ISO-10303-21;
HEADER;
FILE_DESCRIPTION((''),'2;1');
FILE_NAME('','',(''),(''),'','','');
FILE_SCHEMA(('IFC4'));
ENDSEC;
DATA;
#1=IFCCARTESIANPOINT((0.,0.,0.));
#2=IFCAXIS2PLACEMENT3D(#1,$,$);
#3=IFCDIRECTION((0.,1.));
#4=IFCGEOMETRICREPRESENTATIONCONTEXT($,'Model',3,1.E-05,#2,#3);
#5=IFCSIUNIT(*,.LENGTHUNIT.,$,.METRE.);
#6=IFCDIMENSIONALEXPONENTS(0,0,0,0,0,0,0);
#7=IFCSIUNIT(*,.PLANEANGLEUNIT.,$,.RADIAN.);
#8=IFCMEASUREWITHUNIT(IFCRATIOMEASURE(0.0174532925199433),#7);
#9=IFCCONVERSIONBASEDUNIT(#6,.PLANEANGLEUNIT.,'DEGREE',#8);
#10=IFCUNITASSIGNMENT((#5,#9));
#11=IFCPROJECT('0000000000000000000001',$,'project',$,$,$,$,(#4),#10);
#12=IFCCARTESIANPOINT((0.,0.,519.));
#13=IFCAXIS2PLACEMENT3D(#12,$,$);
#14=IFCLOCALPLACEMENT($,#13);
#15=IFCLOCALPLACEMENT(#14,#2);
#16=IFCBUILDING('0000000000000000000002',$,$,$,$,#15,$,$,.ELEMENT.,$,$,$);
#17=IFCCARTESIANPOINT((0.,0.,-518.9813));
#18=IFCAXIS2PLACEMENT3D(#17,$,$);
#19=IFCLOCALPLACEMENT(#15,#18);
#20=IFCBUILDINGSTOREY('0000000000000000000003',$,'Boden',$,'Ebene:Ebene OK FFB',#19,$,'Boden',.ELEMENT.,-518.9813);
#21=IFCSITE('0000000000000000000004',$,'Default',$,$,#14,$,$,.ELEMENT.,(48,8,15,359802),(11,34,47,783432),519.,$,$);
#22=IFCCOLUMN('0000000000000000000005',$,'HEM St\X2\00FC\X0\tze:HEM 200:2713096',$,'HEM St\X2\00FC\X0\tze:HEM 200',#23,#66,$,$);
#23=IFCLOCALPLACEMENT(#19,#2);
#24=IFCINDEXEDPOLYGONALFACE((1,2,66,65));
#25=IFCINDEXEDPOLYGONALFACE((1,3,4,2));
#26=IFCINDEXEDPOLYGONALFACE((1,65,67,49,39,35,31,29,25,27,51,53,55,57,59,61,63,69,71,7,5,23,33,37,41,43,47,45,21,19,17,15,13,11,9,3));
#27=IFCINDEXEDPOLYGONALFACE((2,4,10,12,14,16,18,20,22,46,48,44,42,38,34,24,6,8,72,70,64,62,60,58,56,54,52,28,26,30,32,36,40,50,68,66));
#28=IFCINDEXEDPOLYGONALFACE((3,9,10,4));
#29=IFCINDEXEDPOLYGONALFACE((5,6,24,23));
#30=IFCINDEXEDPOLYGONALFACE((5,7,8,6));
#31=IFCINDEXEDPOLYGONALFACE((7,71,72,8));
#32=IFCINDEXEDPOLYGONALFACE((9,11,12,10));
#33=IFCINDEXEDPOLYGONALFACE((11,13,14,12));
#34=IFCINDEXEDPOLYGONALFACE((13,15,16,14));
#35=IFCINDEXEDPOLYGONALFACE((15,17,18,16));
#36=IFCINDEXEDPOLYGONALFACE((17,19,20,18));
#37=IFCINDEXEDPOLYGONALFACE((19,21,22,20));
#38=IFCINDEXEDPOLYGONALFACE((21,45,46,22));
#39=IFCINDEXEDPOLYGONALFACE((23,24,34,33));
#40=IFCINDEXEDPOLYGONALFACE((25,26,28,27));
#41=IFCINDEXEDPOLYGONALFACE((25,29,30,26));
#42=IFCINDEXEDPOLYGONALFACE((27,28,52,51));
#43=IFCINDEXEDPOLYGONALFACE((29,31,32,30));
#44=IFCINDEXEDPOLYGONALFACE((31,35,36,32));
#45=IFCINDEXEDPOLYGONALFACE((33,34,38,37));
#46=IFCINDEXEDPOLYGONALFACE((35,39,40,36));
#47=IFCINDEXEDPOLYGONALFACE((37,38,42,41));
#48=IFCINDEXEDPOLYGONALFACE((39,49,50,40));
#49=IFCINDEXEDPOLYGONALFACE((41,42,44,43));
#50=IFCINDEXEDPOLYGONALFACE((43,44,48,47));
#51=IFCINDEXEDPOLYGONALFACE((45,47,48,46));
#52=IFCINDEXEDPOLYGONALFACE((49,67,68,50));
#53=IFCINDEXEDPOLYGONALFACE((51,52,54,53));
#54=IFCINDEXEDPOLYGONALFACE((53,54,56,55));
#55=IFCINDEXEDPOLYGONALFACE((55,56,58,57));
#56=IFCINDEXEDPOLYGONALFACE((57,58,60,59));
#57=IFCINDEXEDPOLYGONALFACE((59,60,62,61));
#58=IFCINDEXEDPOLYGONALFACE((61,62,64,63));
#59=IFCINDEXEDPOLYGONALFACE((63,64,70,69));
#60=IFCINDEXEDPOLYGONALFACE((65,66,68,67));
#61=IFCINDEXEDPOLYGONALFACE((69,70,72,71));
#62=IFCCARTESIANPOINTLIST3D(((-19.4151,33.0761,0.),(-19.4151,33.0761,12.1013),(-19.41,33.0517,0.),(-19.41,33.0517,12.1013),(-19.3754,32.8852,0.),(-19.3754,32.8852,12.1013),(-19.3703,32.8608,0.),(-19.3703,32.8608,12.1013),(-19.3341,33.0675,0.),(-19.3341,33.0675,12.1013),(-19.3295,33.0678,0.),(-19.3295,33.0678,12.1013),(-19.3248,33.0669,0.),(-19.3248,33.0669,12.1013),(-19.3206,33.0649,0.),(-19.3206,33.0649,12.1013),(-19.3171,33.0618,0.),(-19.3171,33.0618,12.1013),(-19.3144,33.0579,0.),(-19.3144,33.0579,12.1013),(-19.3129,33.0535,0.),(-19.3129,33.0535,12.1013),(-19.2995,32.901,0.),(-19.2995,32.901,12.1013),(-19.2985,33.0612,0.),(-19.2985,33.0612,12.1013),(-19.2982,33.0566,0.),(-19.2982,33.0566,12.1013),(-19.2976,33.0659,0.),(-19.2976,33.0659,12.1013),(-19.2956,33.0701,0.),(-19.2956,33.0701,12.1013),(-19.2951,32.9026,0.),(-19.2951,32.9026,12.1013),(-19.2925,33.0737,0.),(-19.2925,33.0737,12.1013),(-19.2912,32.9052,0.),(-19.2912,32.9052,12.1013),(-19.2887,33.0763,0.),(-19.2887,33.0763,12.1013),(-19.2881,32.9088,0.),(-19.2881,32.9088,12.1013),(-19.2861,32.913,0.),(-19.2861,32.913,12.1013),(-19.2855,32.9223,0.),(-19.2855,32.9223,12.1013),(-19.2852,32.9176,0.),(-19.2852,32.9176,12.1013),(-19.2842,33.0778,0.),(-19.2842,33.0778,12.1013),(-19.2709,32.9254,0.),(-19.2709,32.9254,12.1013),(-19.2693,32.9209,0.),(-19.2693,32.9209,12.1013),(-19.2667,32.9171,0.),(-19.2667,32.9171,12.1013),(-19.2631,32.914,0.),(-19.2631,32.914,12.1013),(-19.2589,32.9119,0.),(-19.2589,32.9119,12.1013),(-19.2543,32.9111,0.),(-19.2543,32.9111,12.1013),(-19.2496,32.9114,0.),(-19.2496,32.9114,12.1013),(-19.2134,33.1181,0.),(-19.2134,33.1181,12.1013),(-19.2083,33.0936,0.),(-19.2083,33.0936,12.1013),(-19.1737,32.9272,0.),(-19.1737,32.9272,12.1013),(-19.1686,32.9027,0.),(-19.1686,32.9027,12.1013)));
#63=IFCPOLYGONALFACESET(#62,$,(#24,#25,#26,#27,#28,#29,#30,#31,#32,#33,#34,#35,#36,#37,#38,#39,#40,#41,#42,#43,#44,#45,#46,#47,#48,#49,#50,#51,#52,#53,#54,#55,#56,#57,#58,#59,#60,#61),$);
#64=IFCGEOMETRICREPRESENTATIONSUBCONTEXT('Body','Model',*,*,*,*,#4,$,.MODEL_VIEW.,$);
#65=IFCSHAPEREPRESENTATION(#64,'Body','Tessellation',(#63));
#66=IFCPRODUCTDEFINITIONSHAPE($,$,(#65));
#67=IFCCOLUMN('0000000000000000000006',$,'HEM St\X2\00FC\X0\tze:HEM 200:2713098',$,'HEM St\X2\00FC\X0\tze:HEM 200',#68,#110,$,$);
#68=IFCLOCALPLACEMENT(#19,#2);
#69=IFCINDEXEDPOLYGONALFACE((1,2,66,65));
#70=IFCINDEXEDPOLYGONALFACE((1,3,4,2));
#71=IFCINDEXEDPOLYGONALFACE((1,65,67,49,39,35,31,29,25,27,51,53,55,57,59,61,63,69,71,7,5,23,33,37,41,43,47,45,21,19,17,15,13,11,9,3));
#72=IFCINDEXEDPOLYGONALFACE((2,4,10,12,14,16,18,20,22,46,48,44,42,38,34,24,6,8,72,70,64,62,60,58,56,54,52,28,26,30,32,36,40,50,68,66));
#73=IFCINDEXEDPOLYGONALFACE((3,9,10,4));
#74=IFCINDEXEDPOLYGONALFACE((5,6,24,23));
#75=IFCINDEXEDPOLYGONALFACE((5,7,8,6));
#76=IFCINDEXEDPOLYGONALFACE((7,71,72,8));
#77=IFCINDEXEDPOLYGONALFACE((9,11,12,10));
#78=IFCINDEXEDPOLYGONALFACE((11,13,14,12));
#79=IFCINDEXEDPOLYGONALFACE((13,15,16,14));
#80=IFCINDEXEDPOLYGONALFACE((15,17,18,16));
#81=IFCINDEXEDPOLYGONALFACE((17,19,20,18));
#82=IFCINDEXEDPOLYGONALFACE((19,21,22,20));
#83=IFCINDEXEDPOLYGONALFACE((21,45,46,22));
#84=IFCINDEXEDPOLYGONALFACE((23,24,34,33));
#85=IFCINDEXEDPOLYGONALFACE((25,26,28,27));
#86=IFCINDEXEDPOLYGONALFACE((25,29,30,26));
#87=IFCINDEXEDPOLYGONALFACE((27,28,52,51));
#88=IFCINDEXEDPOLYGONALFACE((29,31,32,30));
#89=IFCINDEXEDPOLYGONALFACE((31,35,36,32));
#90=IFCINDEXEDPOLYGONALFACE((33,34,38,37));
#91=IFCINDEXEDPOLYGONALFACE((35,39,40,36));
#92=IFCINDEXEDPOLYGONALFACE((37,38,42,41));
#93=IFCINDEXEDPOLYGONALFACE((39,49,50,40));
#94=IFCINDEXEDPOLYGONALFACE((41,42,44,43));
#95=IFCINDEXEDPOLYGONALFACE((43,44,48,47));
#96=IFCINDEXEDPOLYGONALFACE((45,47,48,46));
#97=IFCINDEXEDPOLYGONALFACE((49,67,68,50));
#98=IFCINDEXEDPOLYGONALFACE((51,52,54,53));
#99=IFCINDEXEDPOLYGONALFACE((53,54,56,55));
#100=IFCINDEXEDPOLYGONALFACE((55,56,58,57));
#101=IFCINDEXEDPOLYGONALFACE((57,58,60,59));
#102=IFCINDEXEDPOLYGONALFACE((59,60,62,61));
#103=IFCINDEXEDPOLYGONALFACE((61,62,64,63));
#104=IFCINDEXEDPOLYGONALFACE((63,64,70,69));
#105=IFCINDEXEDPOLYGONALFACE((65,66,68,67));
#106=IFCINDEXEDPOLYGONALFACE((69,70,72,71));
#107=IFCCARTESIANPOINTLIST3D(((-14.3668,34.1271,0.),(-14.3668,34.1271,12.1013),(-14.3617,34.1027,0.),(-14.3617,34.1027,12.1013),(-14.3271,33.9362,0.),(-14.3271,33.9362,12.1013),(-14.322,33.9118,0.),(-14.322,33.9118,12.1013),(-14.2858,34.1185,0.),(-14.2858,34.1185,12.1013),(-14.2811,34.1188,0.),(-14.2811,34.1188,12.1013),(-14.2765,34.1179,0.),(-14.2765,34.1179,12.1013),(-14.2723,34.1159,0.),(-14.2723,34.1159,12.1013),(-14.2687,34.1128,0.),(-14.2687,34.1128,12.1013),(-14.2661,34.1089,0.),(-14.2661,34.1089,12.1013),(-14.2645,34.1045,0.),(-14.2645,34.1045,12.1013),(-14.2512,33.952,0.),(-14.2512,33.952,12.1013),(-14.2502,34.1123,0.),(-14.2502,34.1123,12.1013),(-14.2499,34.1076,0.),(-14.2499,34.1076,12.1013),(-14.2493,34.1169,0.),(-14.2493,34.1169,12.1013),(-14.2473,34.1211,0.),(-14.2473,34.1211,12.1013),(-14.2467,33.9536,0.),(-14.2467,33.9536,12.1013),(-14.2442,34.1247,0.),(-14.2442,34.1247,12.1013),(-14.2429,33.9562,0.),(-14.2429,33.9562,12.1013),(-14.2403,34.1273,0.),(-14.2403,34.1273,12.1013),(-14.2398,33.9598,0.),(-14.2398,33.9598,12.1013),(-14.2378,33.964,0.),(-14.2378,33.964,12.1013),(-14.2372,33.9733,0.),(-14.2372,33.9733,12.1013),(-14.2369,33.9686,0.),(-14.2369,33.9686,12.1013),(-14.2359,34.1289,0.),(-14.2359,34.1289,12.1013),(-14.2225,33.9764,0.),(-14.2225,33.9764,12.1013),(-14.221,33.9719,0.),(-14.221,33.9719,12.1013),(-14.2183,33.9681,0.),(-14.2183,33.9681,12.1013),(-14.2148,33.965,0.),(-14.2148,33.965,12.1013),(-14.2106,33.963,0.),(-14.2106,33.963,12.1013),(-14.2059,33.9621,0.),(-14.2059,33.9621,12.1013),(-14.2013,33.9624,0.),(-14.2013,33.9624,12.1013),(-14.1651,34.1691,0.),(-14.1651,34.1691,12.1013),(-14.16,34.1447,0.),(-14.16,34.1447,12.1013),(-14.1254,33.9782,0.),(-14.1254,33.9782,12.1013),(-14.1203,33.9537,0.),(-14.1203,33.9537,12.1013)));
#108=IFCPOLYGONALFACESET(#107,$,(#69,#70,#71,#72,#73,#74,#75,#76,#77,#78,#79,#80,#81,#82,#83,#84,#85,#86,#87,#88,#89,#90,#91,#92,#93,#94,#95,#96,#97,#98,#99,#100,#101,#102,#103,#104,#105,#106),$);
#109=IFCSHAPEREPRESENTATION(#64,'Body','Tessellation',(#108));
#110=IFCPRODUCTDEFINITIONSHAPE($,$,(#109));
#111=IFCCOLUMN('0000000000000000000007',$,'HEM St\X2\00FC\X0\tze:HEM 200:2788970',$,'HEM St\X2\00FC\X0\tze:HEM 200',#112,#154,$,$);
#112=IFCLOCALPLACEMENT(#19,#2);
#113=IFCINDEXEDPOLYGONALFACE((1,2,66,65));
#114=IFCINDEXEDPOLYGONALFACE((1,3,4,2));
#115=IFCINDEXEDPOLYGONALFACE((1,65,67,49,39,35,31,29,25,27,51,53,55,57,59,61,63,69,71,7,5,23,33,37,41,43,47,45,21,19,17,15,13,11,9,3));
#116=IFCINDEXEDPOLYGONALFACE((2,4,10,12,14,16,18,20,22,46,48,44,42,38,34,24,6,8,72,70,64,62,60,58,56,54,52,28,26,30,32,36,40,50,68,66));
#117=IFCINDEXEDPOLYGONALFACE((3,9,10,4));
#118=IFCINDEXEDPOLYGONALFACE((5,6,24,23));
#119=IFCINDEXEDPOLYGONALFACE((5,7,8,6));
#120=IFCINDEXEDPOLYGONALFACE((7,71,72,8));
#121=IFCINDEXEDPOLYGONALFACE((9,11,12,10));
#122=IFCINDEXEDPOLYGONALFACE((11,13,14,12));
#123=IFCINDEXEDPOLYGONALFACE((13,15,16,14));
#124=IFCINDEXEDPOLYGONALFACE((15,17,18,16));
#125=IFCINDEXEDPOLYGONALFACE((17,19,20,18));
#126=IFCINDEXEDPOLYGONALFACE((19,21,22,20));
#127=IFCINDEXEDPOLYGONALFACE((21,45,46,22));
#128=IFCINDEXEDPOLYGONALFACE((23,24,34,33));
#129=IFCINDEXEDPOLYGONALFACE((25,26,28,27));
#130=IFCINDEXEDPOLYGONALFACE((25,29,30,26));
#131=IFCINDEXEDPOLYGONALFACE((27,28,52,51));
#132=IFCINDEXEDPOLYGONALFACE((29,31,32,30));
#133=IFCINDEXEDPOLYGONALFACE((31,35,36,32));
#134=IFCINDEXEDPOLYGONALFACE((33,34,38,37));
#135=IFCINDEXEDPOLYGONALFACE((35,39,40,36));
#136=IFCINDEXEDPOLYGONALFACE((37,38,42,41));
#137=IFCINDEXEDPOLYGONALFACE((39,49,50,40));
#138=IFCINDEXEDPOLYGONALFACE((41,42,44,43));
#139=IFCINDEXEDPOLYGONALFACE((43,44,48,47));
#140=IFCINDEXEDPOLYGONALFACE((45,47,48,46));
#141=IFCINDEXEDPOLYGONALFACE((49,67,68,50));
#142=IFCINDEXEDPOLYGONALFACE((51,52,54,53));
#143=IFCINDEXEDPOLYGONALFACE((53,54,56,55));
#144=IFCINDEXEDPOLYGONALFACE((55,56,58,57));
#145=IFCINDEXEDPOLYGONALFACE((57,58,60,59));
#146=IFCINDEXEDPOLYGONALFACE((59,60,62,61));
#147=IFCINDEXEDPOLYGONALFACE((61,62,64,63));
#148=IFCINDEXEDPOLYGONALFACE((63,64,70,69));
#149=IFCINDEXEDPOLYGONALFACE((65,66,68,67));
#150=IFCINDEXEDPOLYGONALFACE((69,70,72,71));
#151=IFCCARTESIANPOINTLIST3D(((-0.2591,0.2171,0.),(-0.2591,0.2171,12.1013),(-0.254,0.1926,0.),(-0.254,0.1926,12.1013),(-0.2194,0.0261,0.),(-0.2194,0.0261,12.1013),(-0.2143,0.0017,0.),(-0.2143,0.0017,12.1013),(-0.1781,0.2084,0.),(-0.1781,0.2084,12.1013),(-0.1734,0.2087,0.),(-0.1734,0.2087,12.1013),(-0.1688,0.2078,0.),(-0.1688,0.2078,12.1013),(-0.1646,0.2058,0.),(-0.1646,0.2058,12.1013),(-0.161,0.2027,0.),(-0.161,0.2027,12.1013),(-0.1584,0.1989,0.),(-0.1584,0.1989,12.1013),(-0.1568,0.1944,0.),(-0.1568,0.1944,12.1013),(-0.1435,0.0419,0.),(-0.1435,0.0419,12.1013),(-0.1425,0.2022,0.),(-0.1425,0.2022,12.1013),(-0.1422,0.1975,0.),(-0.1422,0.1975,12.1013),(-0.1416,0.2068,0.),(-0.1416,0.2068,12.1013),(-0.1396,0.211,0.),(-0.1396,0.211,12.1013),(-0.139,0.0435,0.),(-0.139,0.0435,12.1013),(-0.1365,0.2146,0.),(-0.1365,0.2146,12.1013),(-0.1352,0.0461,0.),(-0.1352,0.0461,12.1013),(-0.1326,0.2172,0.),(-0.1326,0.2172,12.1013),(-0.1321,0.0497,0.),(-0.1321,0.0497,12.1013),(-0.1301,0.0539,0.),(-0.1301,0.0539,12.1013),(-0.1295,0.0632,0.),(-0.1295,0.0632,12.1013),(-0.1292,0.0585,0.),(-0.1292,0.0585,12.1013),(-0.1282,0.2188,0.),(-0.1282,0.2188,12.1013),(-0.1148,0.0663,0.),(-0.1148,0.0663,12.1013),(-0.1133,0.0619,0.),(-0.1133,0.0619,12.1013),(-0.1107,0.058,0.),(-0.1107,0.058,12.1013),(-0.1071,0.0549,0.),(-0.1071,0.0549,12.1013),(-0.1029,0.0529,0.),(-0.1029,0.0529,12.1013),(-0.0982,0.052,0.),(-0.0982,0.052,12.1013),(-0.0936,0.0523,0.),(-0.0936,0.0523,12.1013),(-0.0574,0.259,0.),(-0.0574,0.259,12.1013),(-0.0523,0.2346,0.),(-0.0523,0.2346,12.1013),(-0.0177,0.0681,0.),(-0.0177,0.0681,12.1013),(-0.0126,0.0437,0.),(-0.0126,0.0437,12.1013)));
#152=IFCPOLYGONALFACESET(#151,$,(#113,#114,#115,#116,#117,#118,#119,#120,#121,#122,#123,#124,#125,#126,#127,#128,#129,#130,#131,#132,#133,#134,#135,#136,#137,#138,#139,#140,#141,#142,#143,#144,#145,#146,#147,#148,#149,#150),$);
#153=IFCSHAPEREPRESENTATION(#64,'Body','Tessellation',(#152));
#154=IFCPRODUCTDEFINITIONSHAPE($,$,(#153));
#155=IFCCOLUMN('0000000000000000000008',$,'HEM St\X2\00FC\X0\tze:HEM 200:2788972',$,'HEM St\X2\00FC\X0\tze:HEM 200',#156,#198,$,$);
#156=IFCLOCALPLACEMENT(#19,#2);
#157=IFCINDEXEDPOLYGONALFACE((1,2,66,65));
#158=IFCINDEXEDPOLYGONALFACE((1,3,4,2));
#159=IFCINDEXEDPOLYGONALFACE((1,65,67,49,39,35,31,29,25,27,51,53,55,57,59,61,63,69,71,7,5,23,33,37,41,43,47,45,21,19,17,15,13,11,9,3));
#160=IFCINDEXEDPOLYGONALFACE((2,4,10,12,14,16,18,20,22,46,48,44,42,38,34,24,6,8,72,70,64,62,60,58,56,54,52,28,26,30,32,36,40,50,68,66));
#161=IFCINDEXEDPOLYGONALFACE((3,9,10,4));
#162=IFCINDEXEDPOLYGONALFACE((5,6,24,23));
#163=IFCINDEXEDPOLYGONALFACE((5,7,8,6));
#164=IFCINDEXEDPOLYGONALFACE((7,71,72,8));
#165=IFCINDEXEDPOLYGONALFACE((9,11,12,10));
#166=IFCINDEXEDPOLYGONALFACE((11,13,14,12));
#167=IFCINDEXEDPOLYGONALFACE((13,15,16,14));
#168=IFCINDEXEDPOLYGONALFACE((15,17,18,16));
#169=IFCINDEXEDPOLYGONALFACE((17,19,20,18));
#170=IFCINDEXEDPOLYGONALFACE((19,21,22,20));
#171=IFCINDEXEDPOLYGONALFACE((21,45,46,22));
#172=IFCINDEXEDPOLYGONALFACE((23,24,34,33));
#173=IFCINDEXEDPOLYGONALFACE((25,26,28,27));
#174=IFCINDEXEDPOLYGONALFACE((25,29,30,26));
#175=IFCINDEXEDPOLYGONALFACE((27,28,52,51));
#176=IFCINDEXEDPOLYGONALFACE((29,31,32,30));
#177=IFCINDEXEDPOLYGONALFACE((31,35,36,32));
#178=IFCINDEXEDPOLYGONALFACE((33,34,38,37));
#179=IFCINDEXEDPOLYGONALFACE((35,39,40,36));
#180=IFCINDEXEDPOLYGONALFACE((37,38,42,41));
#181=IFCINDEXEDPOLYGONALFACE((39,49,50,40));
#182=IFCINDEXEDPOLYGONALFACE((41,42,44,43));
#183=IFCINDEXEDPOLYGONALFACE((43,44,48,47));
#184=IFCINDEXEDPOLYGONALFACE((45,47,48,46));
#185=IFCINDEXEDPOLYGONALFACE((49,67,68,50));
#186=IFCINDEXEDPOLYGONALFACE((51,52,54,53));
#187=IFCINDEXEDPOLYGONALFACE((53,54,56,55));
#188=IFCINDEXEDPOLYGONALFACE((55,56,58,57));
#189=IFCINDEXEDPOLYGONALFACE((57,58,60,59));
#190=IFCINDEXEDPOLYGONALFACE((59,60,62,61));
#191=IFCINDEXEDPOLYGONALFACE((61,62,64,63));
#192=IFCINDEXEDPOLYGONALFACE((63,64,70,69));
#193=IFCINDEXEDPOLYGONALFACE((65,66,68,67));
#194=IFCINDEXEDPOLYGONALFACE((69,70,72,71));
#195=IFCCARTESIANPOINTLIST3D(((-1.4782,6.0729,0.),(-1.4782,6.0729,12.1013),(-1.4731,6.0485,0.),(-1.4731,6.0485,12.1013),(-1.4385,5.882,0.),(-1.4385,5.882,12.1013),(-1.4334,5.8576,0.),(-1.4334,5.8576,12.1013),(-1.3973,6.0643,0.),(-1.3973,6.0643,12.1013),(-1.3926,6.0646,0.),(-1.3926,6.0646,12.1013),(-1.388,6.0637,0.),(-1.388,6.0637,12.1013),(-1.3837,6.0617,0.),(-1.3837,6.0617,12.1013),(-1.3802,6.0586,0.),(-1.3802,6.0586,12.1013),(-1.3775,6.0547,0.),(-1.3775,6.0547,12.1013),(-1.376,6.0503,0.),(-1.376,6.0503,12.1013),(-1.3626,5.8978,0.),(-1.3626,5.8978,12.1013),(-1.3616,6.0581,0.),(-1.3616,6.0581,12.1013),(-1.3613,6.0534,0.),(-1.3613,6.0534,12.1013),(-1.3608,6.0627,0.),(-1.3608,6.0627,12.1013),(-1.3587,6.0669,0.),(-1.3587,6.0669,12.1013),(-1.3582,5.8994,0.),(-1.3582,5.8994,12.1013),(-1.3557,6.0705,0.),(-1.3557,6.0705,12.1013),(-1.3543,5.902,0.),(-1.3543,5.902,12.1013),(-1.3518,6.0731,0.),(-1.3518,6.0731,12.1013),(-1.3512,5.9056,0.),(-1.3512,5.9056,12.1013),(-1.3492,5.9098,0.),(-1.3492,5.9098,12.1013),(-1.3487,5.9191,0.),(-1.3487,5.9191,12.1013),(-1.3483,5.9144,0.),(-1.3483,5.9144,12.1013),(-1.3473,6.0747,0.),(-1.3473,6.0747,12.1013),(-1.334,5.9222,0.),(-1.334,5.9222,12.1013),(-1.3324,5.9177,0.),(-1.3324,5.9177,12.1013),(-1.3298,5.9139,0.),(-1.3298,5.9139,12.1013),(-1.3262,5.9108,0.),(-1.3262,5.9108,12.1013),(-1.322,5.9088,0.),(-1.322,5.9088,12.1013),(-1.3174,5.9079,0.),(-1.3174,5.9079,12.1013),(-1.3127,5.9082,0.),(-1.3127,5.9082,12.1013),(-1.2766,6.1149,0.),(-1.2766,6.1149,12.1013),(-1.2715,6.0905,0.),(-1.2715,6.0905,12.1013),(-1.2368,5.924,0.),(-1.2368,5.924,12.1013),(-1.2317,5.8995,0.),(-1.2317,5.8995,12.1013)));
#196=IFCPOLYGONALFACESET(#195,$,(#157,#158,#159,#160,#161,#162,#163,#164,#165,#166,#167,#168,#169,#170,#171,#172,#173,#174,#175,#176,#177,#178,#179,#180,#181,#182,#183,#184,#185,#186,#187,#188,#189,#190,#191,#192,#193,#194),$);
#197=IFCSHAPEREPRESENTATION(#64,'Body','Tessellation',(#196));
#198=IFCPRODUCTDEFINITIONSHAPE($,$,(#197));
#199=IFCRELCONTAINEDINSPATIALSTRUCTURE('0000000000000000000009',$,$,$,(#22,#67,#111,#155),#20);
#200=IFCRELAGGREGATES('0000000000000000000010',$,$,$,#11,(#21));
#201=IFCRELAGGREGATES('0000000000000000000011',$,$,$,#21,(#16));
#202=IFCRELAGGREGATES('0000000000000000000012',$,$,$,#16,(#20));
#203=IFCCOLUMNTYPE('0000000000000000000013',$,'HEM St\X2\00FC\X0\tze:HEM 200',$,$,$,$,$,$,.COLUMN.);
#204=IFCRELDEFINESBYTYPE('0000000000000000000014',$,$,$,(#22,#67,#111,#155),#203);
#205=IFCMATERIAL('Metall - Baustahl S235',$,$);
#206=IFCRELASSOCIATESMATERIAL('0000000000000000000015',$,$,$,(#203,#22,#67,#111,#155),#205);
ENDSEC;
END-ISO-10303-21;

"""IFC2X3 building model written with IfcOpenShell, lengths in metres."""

from ifc_helpers import new_model, entity, si_unit, converted_unit, direction, frame, frame_2d, origin, place, context, subcontext, project, spatial, polyline, circle_curve, parameter, trimmed, segment, composite_curve, outline, extrude, source, transform, mapped, material, type_object, type_shapes, element, save


model = new_model("IFC2X3")

# Units and contexts
model_context = context("Model", 3, precision=1e-05, world=origin(), true_north=direction((0.0, 1.0)))
body_context = subcontext(model_context, "Body", "Model", "MODEL_VIEW")
ifc_project = project(units=[si_unit("LENGTHUNIT", "METRE"), converted_unit("PLANEANGLEUNIT", "DEGREE", entity("IfcRatioMeasure", 0.0174532925199433), si_unit("PLANEANGLEUNIT", "RADIAN"), dimensions=[0, 0, 0, 0, 0, 0, 0])], contexts=[model_context])

# Site, building, storey
site_placement = place(None, frame((0.0, 0.0, 519.0)))
site = spatial("IfcSite", under=ifc_project, at=site_placement, Name="Default", CompositionType="ELEMENT", RefLatitude=(48, 8, 15, 359802), RefLongitude=(11, 34, 47, 783432), RefElevation=519.0)
building_placement = place(site_placement, origin())
building = spatial("IfcBuilding", under=site, at=building_placement, CompositionType="ELEMENT")
storey_placement = place(building_placement, frame((0.0, 0.0, -518.9813)))
storey = spatial("IfcBuildingStorey", under=building, at=storey_placement, Name="Boden", ObjectType="Ebene:Ebene OK FFB", LongName="Boden", CompositionType="ELEMENT", Elevation=-518.9813)

# Columns
ifc_material = material(Name="Metall - Baustahl S235")
column_type_1 = type_object("IfcColumnType", Name="HEM Stütze:HEM 200", PredefinedType="COLUMN", material=ifc_material)
shared_shape_1 = source(origin(), body_context, "Body", "SweptSolid", [
    extrude(outline(composite_curve([segment(polyline([(0.085, -0.103), (0.11, -0.103)]), True, "CONTINUOUS"), segment(polyline([(0.11, -0.103), (0.11, 0.103)]), True, "CONTINUOUS"), segment(polyline([(0.11, 0.103), (0.085, 0.103)]), True, "CONTINUOUS"), segment(polyline([(0.085, 0.103), (0.085, 0.0255)]), True, "CONTINUOUS"), segment(trimmed(circle_curve(frame_2d((0.067, 0.0255), x_axis=(1.0, 0.0)), 0.018), [parameter(270.0)], [parameter(0.0)], True, "PARAMETER"), False, "CONTINUOUS"), segment(polyline([(0.067, 0.0075), (-0.067, 0.0075)]), True, "CONTINUOUS"), segment(trimmed(circle_curve(frame_2d((-0.067, 0.0255), x_axis=(0.0, -1.0)), 0.018), [parameter(270.0)], [parameter(0.0)], True, "PARAMETER"), False, "CONTINUOUS"), segment(polyline([(-0.085, 0.0255), (-0.085, 0.103)]), True, "CONTINUOUS"), segment(polyline([(-0.085, 0.103), (-0.11, 0.103)]), True, "CONTINUOUS"), segment(polyline([(-0.11, 0.103), (-0.11, -0.103)]), True, "CONTINUOUS"), segment(polyline([(-0.11, -0.103), (-0.085, -0.103)]), True, "CONTINUOUS"), segment(polyline([(-0.085, -0.103), (-0.085, -0.0255)]), True, "CONTINUOUS"), segment(trimmed(circle_curve(frame_2d((-0.067, -0.0255), x_axis=(-1.0, 0.0)), 0.018), [parameter(270.0)], [parameter(0.0)], True, "PARAMETER"), False, "CONTINUOUS"), segment(polyline([(-0.067, -0.0075), (0.067, -0.0075)]), True, "CONTINUOUS"), segment(trimmed(circle_curve(frame_2d((0.067, -0.0255), x_axis=(0.0, 1.0)), 0.018), [parameter(270.0)], [parameter(0.0)], True, "PARAMETER"), False, "CONTINUOUS"), segment(polyline([(0.085, -0.0255), (0.085, -0.103)]), True, "CONTINUOUS")], self_intersect=False)), frame((0.0, 0.0, -518.9813), z_axis=(0.0, 0.0, 1.0), x_axis=(0.0, -1.0, 0.0)), (0.0, 0.0, 1.0), 12.1013),
])
type_shapes(column_type_1, [shared_shape_1])
for number, where, z_axis, x_axis, name in (
    (1, (-19.2919, 32.9894, 518.9813), (0.0, 0.0, 1.0), (0.979008, 0.20382, 0.0), "HEM Stütze:HEM 200:2713096"),
    (2, (-14.2435, 34.0404, 518.9813), (0.0, 0.0, 1.0), (0.979008, 0.20382, 0.0), "HEM Stütze:HEM 200:2713098"),
    (3, (-0.1358, 0.1304, 518.9813), (0.0, 0.0, 1.0), (0.979008, 0.20382, 0.0), "HEM Stütze:HEM 200:2788970"),
    (4, (-1.355, 5.9862, 518.9813), (0.0, 0.0, 1.0), (0.979008, 0.20382, 0.0), "HEM Stütze:HEM 200:2788972"),
):
    element("IfcColumn", number, at=place(storey_placement, frame(where, z_axis=z_axis, x_axis=x_axis)), inside=storey, type_object=column_type_1, material=ifc_material, Name=name, ObjectType="HEM Stütze:HEM 200", context=body_context, shape_type="MappedRepresentation", body=[
        mapped(shared_shape_1, transform((0.0, 0.0, 0.0), scale=1.0)),
    ])

save(model, "model.ifc")
